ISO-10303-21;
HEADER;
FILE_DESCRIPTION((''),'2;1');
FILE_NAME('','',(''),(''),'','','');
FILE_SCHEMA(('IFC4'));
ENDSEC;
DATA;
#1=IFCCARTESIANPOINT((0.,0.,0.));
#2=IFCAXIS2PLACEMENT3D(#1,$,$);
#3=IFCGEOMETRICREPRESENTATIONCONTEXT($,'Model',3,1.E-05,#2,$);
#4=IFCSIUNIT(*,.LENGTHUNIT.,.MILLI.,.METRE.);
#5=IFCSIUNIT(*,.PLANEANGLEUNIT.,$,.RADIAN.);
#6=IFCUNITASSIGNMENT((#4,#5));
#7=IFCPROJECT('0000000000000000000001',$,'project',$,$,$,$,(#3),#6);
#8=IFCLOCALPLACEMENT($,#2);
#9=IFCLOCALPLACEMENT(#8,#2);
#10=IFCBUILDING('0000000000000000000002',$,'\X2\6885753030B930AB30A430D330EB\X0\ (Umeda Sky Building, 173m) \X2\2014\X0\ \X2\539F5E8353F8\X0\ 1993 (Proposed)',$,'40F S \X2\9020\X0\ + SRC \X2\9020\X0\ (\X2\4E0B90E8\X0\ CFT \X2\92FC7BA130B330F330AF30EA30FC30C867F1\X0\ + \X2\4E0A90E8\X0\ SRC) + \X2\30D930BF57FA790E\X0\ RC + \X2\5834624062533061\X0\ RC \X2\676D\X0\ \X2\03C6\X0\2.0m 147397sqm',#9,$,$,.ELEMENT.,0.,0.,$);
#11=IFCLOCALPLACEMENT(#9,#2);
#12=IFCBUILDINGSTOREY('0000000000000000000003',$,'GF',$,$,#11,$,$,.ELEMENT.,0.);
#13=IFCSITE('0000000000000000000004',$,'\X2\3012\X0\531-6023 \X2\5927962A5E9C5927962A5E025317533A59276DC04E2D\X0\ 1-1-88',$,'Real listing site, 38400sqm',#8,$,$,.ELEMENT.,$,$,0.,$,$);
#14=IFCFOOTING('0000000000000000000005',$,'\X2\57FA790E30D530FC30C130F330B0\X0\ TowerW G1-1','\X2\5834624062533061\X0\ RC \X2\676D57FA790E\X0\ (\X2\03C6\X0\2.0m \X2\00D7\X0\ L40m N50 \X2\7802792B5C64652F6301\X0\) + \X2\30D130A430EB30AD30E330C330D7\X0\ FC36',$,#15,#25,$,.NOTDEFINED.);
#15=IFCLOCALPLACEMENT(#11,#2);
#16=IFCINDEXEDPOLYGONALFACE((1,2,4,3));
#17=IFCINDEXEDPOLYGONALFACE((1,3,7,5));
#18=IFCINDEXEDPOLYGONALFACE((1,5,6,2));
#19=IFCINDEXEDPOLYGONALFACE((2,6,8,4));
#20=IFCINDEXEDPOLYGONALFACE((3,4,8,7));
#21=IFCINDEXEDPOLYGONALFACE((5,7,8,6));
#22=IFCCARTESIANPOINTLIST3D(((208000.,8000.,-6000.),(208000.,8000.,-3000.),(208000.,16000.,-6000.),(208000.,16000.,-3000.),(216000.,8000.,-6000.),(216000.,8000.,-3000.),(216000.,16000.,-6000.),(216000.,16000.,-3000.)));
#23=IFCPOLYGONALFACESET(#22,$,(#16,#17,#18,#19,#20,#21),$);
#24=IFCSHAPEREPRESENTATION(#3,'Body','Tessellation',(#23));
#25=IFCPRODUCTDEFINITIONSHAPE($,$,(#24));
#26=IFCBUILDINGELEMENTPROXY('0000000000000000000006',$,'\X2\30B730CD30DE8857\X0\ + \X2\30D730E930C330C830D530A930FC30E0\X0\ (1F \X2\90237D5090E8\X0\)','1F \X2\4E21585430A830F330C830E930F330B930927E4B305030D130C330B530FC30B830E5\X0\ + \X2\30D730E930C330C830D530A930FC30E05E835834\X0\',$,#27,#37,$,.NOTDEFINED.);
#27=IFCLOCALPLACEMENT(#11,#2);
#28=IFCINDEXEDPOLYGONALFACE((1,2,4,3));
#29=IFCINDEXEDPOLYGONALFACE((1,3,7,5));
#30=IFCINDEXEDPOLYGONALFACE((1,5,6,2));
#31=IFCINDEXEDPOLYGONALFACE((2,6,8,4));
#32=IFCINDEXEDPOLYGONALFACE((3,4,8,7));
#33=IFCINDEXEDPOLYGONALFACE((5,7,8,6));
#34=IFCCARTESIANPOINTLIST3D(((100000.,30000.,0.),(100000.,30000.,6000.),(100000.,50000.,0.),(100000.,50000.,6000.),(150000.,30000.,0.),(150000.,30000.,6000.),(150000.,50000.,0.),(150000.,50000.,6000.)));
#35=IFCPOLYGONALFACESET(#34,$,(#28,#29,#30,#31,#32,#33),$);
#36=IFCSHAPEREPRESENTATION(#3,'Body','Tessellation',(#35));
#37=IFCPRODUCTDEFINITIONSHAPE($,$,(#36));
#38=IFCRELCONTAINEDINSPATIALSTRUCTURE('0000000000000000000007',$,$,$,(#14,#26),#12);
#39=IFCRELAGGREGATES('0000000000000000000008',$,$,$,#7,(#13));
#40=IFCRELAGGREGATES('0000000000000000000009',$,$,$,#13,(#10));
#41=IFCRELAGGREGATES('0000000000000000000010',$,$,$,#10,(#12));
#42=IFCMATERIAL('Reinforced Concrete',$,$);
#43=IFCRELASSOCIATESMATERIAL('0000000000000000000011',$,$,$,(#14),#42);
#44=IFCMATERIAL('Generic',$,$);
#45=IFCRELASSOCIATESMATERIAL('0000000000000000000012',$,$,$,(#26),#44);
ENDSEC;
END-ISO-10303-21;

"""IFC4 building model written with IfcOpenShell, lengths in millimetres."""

from ifc_helpers import new_model, si_unit, frame, frame_2d, origin, place, context, project, spatial, rectangle, extrude, material, element, save


model = new_model("IFC4")

# Units and contexts
model_context = context("Model", 3, precision=1e-05, world=origin())
ifc_project = project(units=[si_unit("LENGTHUNIT", "METRE", prefix="MILLI"), si_unit("PLANEANGLEUNIT", "RADIAN")], contexts=[model_context])

# Site, building, storey
site_placement = place(None, origin())
site = spatial("IfcSite", under=ifc_project, at=site_placement, Name="〒531-6023 大阪府大阪市北区大淀中 1-1-88", ObjectType="Real listing site, 38400sqm", CompositionType="ELEMENT", RefElevation=0.0)
building_placement = place(site_placement, origin())
building = spatial("IfcBuilding", under=site, at=building_placement, Name="梅田スカイビル (Umeda Sky Building, 173m) — 原広司 1993 (Proposed)", ObjectType="40F S 造 + SRC 造 (下部 CFT 鋼管コンクリート柱 + 上部 SRC) + ベタ基礎 RC + 場所打ち RC 杭 φ2.0m 147397sqm", CompositionType="ELEMENT", ElevationOfRefHeight=0.0, ElevationOfTerrain=0.0)
storey_placement = place(building_placement, origin())
storey = spatial("IfcBuildingStorey", under=building, at=storey_placement, Name="GF", CompositionType="ELEMENT", Elevation=0.0)

# Footing
ifc_material_1 = material(Name="Reinforced Concrete")
footing_1_placement = place(storey_placement, frame((104000.0, 4000.0, -3000.0)))
element("IfcFooting", 1, at=footing_1_placement, inside=storey, material=ifc_material_1, Name="基礎フーチング TowerW G1-1", Description="場所打ち RC 杭基礎 (φ2.0m × L40m N50 砂礫層支持) + パイルキャップ FC36", PredefinedType="NOTDEFINED", context=model_context, shape_type="SweptSolid", body=[
    extrude(rectangle(XDim=8000.0, YDim=8000.0, at=frame_2d((4000.0, 4000.0))), frame((104000.0, 4000.0, -3000.0)), (0.0, 0.0, 1.0), 3000.0),
])

# Shared definitions
ifc_material_2 = material(Name="Generic")

# Building element proxy
proxy_placement = place(storey_placement, frame((50000.0, 15000.0, 0.0)))
element("IfcBuildingElementProxy", 2, at=proxy_placement, inside=storey, material=ifc_material_2, Name="シネマ街 + プラットフォーム (1F 連結部)", Description="1F 両塔エントランスを繋ぐパッサージュ + プラットフォーム広場", PredefinedType="NOTDEFINED", context=model_context, shape_type="SweptSolid", body=[
    extrude(rectangle(XDim=50000.0, YDim=20000.0, at=frame_2d((25000.0, 10000.0))), frame((50000.0, 15000.0, 0.0)), (0.0, 0.0, 1.0), 6000.0),
])

save(model, "model.ifc")
